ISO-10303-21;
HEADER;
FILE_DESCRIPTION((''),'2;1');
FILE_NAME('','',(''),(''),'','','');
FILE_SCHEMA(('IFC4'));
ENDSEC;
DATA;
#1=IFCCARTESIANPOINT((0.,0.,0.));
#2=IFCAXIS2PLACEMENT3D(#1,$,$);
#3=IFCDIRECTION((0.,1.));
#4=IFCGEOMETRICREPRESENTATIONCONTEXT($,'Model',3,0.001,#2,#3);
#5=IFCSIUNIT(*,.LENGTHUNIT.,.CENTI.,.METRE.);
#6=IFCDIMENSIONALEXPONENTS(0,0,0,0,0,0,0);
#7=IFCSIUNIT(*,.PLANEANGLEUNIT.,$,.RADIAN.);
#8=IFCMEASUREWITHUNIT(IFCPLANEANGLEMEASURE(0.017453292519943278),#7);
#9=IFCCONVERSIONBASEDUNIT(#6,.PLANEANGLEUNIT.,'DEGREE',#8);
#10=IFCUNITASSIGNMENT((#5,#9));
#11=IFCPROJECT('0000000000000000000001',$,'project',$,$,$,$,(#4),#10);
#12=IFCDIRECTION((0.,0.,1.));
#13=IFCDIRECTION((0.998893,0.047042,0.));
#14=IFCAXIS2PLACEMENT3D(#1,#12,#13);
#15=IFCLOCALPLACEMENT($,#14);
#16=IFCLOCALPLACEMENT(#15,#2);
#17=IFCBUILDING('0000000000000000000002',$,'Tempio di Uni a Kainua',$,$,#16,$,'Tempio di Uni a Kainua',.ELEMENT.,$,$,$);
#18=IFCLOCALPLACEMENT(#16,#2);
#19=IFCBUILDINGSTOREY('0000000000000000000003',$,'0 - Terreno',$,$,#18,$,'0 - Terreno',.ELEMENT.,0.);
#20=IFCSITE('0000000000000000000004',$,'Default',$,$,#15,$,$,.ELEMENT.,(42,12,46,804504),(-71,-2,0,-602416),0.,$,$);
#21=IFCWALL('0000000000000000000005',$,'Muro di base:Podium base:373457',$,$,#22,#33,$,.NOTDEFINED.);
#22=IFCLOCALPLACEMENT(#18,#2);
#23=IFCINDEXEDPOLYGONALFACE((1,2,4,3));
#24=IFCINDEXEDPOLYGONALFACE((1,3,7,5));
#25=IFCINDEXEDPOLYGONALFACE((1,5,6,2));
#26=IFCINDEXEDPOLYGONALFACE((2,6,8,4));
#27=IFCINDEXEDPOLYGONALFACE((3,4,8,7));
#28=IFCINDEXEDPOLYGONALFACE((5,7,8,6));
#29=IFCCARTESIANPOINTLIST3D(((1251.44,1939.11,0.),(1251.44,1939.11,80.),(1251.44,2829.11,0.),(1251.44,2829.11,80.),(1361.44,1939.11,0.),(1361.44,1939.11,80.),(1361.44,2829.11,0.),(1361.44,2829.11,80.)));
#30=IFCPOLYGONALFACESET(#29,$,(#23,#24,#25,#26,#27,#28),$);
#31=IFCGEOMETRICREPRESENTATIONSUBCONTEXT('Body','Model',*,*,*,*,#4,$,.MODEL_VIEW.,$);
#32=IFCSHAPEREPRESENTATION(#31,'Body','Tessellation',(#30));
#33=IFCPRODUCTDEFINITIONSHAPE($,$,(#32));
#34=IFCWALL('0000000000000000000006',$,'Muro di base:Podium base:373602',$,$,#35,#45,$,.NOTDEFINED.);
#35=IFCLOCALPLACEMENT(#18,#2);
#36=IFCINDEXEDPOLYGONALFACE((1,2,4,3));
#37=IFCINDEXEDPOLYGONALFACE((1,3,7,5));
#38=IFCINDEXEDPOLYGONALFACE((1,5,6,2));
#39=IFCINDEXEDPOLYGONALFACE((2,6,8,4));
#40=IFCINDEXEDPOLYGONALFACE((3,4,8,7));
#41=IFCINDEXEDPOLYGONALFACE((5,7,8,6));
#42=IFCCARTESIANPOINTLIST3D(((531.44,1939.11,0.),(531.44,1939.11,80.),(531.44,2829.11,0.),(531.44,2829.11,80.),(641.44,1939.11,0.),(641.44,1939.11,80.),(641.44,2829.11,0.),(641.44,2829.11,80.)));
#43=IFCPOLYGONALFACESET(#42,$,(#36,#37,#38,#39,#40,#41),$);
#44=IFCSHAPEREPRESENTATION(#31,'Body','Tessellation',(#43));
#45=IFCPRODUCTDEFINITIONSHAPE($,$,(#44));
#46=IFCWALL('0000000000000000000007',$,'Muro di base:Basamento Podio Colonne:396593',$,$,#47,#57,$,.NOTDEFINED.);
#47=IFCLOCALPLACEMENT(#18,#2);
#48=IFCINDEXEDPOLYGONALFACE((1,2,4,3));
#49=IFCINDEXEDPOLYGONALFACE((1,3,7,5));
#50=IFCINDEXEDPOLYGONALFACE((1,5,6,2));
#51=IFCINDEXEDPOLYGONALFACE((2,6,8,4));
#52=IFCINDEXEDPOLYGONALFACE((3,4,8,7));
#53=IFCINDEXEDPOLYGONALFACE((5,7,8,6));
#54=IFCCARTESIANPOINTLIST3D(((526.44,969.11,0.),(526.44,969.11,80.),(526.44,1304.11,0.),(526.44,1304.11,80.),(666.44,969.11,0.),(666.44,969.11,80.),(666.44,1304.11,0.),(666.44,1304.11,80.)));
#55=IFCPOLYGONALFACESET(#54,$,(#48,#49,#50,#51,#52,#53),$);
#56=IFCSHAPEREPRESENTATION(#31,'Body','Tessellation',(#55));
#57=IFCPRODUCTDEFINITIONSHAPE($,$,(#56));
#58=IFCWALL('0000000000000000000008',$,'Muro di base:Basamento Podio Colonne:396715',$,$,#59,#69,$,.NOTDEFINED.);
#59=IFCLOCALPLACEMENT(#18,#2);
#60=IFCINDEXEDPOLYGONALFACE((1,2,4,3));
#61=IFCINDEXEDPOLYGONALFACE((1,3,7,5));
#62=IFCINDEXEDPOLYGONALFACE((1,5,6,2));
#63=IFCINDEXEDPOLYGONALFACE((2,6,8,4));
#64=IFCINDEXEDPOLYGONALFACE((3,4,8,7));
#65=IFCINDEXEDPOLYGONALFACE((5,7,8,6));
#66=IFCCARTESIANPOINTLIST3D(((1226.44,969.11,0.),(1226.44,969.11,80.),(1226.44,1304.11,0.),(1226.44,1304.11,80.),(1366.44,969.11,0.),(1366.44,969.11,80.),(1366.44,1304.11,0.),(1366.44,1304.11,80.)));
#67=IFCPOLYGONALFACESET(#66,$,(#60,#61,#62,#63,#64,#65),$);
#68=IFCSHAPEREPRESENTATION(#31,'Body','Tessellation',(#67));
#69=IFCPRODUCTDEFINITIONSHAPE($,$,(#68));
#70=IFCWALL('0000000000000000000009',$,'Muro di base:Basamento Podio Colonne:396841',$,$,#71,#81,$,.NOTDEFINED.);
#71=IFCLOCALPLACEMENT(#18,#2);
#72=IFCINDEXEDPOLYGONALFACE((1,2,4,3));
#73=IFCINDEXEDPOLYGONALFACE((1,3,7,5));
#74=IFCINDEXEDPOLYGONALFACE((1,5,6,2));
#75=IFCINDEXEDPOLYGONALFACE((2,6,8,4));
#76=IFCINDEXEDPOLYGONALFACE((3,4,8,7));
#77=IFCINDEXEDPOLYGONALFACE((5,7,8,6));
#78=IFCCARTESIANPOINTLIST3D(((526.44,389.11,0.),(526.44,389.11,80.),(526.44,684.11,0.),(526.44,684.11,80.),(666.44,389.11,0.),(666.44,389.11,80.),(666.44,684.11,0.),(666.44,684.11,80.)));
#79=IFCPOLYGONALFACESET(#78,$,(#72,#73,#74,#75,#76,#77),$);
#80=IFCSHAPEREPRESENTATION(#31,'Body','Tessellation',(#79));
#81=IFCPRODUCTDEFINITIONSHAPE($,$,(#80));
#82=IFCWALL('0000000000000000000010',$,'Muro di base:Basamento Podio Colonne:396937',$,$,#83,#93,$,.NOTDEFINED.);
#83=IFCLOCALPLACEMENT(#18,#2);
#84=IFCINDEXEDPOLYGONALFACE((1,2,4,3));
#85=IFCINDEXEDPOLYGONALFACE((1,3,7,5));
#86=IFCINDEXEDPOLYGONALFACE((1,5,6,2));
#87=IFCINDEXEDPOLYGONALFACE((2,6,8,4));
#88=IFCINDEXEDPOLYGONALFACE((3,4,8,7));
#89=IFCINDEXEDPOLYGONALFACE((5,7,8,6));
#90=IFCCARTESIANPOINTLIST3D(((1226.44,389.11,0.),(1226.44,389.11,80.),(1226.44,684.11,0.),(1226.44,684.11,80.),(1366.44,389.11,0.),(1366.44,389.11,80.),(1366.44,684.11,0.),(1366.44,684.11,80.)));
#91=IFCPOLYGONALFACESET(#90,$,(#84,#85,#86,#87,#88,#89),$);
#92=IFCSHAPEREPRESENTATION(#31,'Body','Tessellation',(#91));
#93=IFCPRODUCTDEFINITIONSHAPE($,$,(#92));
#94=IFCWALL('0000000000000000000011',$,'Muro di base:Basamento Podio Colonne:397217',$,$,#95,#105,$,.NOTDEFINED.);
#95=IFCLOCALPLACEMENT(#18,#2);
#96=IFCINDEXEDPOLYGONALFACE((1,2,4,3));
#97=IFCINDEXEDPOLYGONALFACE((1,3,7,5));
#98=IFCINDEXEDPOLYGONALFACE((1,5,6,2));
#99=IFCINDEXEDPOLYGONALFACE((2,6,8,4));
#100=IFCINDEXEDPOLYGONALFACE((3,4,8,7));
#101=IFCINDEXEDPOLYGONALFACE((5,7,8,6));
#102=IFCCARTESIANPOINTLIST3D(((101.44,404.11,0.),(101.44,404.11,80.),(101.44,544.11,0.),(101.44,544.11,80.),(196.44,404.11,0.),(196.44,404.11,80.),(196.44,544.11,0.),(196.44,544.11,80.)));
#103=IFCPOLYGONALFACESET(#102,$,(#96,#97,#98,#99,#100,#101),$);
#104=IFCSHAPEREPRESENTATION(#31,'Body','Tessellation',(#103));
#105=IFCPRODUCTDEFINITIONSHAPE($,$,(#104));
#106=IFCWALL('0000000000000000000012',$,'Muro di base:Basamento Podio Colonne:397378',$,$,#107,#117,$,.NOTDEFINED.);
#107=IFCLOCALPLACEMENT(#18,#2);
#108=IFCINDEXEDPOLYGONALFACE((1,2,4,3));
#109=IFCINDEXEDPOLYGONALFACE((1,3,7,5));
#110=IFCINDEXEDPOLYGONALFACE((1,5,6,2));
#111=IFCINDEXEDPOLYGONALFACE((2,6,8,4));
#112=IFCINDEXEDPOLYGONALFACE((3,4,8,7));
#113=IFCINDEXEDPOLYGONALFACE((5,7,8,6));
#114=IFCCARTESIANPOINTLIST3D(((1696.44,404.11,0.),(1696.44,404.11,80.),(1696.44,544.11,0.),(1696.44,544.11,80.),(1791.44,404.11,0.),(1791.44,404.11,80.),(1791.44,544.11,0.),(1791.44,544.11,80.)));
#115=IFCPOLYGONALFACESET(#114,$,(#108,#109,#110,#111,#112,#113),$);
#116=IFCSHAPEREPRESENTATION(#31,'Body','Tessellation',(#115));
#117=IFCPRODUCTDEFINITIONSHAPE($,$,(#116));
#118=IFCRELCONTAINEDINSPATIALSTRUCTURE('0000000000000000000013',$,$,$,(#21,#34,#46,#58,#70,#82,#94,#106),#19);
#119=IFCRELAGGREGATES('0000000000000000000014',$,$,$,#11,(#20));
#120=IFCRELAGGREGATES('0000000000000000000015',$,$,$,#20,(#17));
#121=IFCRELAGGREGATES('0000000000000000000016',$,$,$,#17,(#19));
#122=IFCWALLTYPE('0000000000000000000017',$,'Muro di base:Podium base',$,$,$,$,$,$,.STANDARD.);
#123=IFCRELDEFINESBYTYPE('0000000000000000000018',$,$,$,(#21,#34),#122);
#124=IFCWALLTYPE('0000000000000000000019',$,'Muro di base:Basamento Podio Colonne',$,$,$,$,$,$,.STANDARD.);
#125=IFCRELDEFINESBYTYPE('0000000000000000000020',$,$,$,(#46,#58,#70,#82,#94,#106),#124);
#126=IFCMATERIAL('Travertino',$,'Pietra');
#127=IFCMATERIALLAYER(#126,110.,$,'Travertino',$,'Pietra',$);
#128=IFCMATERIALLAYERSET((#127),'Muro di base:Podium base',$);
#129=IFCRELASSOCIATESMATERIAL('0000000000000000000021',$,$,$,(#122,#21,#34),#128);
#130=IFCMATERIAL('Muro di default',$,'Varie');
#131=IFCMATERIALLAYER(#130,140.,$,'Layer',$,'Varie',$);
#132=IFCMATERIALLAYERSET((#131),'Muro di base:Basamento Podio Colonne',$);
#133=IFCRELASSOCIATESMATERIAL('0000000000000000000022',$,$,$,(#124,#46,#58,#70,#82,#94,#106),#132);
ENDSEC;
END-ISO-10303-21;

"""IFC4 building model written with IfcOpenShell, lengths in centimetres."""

from ifc_helpers import new_model, entity, si_unit, converted_unit, direction, frame, frame_2d, origin, place, context, subcontext, project, spatial, polyline, rectangle, extrude, clip, bounded_halfspace, material, layer, layer_set, layer_usage, type_object, element, save


model = new_model("IFC4")

# Units and contexts
model_context = context("Model", 3, precision=0.001, world=origin(), true_north=direction((0.0, 1.0)))
body_context = subcontext(model_context, "Body", "Model", "MODEL_VIEW")
ifc_project = project(units=[si_unit("LENGTHUNIT", "METRE", prefix="CENTI"), converted_unit("PLANEANGLEUNIT", "DEGREE", entity("IfcPlaneAngleMeasure", 0.017453292519943278), si_unit("PLANEANGLEUNIT", "RADIAN"), dimensions=[0, 0, 0, 0, 0, 0, 0])], contexts=[model_context])

# Site, building, storey
site_placement = place(None, frame((0.0, 0.0, 0.0), z_axis=(0.0, 0.0, 1.0), x_axis=(0.998893, 0.047042, 0.0)))
site = spatial("IfcSite", under=ifc_project, at=site_placement, Name="Default", CompositionType="ELEMENT", RefLatitude=(42, 12, 46, 804504), RefLongitude=(-71, -2, 0, -602416), RefElevation=0.0)
building_placement = place(site_placement, origin())
building = spatial("IfcBuilding", under=site, at=building_placement, Name="Tempio di Uni a Kainua", LongName="Tempio di Uni a Kainua", CompositionType="ELEMENT")
storey_placement = place(building_placement, origin())
storey = spatial("IfcBuildingStorey", under=building, at=storey_placement, Name="0 - Terreno", LongName="0 - Terreno", CompositionType="ELEMENT", Elevation=0.0)

# Walls
ifc_material_1 = material(Name="Travertino", Category="Pietra")
ifc_layer_1 = layer(ifc_material_1, 110.0, Name="Travertino", Category="Pietra")
ifc_layer_set_1 = layer_set([ifc_layer_1], Name="Muro di base:Podium base")
wall_type_1 = type_object("IfcWallType", Name="Muro di base:Podium base", PredefinedType="STANDARD", material=ifc_layer_set_1)
ifc_layer_usage_1 = layer_usage(ifc_layer_set_1, "AXIS2", "NEGATIVE", 55.0)
wall_1_placement = place(storey_placement, frame((1306.44, 1939.11, 0.0), z_axis=(0.0, 0.0, 1.0), x_axis=(0.0, 1.0, 0.0)))
element("IfcWall", 1, at=wall_1_placement, inside=storey, type_object=wall_type_1, material=ifc_layer_usage_1, Name="Muro di base:Podium base:373457", PredefinedType="NOTDEFINED", context=body_context, shape_type="Clipping", body=[
    clip(extrude(rectangle(XDim=890.0, YDim=110.0, at=frame_2d((445.0, 0.0), x_axis=(-1.0, 0.0))), origin(), (0.0, 0.0, 1.0), 80.0), bounded_halfspace(frame((0.0, -55.0, 80.0), z_axis=(0.0, 0.0, -1.0), x_axis=(-1.0, 0.0, 0.0)), True, frame((0.0, -55.0, 80.0)), polyline([(0.0, 0.0), (340.0, 0.0), (450.0, 0.0), (890.0, 0.0), (890.0, 110.0), (750.0, 110.0), (640.0, 110.0), (0.0, 110.0), (0.0, 0.0)]))),
])
ifc_layer_usage_2 = layer_usage(ifc_layer_set_1, "AXIS2", "NEGATIVE", 55.0)
wall_2_placement = place(storey_placement, frame((586.44, 1939.11, 0.0), z_axis=(0.0, 0.0, 1.0), x_axis=(0.0, 1.0, 0.0)))
element("IfcWall", 2, at=wall_2_placement, inside=storey, type_object=wall_type_1, material=ifc_layer_usage_2, Name="Muro di base:Podium base:373602", PredefinedType="NOTDEFINED", context=body_context, shape_type="Clipping", body=[
    clip(extrude(rectangle(XDim=890.0, YDim=110.0, at=frame_2d((445.0, 0.0), x_axis=(-1.0, 0.0))), origin(), (0.0, 0.0, 1.0), 80.0), bounded_halfspace(frame((0.0, -55.0, 80.0), z_axis=(0.0, 0.0, -1.0), x_axis=(-1.0, 0.0, 0.0)), True, frame((0.0, -55.0, 80.0)), polyline([(0.0, 0.0), (640.0, 0.0), (750.0, 0.0), (890.0, 0.0), (890.0, 110.0), (450.0, 110.0), (340.0, 110.0), (0.0, 110.0), (0.0, 0.0)]))),
])
ifc_material_2 = material(Name="Muro di default", Category="Varie")
ifc_layer_2 = layer(ifc_material_2, 140.0, Name="Layer", Category="Varie")
ifc_layer_set_2 = layer_set([ifc_layer_2], Name="Muro di base:Basamento Podio Colonne")
ifc_layer_usage_3 = layer_usage(ifc_layer_set_2, "AXIS2", "NEGATIVE", 70.0)
wall_type_2 = type_object("IfcWallType", Name="Muro di base:Basamento Podio Colonne", PredefinedType="STANDARD", material=ifc_layer_set_2)
wall_3_placement = place(storey_placement, frame((596.44, 969.11, 0.0), z_axis=(0.0, 0.0, 1.0), x_axis=(0.0, 1.0, 0.0)))
element("IfcWall", 3, at=wall_3_placement, inside=storey, type_object=wall_type_2, material=ifc_layer_usage_3, Name="Muro di base:Basamento Podio Colonne:396593", PredefinedType="NOTDEFINED", context=body_context, shape_type="Clipping", body=[
    clip(extrude(rectangle(XDim=335.0, YDim=140.0, at=frame_2d((167.5, 0.0), x_axis=(-1.0, 0.0))), origin(), (0.0, 0.0, 1.0), 80.0), bounded_halfspace(frame((0.0, -70.0, 80.0), z_axis=(0.0, 0.0, -1.0), x_axis=(-1.0, 0.0, 0.0)), True, frame((0.0, -70.0, 80.0)), polyline([(0.0, 0.0), (335.0, 0.0), (335.0, 140.0), (0.0, 140.0), (0.0, 0.0)]))),
])
ifc_layer_usage_4 = layer_usage(ifc_layer_set_2, "AXIS2", "NEGATIVE", 70.0)
wall_4_placement = place(storey_placement, frame((1296.44, 969.11, 0.0), z_axis=(0.0, 0.0, 1.0), x_axis=(0.0, 1.0, 0.0)))
element("IfcWall", 4, at=wall_4_placement, inside=storey, type_object=wall_type_2, material=ifc_layer_usage_4, Name="Muro di base:Basamento Podio Colonne:396715", PredefinedType="NOTDEFINED", context=body_context, shape_type="Clipping", body=[
    clip(extrude(rectangle(XDim=335.0, YDim=140.0, at=frame_2d((167.5, 0.0), x_axis=(-1.0, 0.0))), origin(), (0.0, 0.0, 1.0), 80.0), bounded_halfspace(frame((0.0, -70.0, 80.0), z_axis=(0.0, 0.0, -1.0), x_axis=(-1.0, 0.0, 0.0)), True, frame((0.0, -70.0, 80.0)), polyline([(0.0, 0.0), (335.0, 0.0), (335.0, 140.0), (0.0, 140.0), (0.0, 0.0)]))),
])
ifc_layer_usage_5 = layer_usage(ifc_layer_set_2, "AXIS2", "NEGATIVE", 70.0)
wall_5_placement = place(storey_placement, frame((596.44, 389.11, 0.0), z_axis=(0.0, 0.0, 1.0), x_axis=(0.0, 1.0, 0.0)))
element("IfcWall", 5, at=wall_5_placement, inside=storey, type_object=wall_type_2, material=ifc_layer_usage_5, Name="Muro di base:Basamento Podio Colonne:396841", PredefinedType="NOTDEFINED", context=body_context, shape_type="Clipping", body=[
    clip(extrude(rectangle(XDim=295.0, YDim=140.0, at=frame_2d((147.5, 0.0), x_axis=(-1.0, 0.0))), origin(), (0.0, 0.0, 1.0), 80.0), bounded_halfspace(frame((0.0, -70.0, 80.0), z_axis=(0.0, 0.0, -1.0), x_axis=(-1.0, 0.0, 0.0)), True, frame((0.0, -70.0, 80.0)), polyline([(0.0, 0.0), (295.0, 0.0), (295.0, 140.0), (0.0, 140.0), (0.0, 0.0)]))),
])
ifc_layer_usage_6 = layer_usage(ifc_layer_set_2, "AXIS2", "NEGATIVE", 70.0)
wall_6_placement = place(storey_placement, frame((1296.44, 389.11, 0.0), z_axis=(0.0, 0.0, 1.0), x_axis=(0.0, 1.0, 0.0)))
element("IfcWall", 6, at=wall_6_placement, inside=storey, type_object=wall_type_2, material=ifc_layer_usage_6, Name="Muro di base:Basamento Podio Colonne:396937", PredefinedType="NOTDEFINED", context=body_context, shape_type="Clipping", body=[
    clip(extrude(rectangle(XDim=295.0, YDim=140.0, at=frame_2d((147.5, 0.0), x_axis=(-1.0, 0.0))), origin(), (0.0, 0.0, 1.0), 80.0), bounded_halfspace(frame((0.0, -70.0, 80.0), z_axis=(0.0, 0.0, -1.0), x_axis=(-1.0, 0.0, 0.0)), True, frame((0.0, -70.0, 80.0)), polyline([(0.0, 0.0), (295.0, 0.0), (295.0, 140.0), (0.0, 140.0), (0.0, 0.0)]))),
])
ifc_layer_usage_7 = layer_usage(ifc_layer_set_2, "AXIS2", "NEGATIVE", 70.0)
wall_7_placement = place(storey_placement, frame((101.44, 474.11, 0.0)))
element("IfcWall", 7, at=wall_7_placement, inside=storey, type_object=wall_type_2, material=ifc_layer_usage_7, Name="Muro di base:Basamento Podio Colonne:397217", PredefinedType="NOTDEFINED", context=body_context, shape_type="Clipping", body=[
    clip(extrude(rectangle(XDim=95.0, YDim=140.0, at=frame_2d((47.5, 0.0), x_axis=(-1.0, 0.0))), origin(), (0.0, 0.0, 1.0), 80.0), bounded_halfspace(frame((0.0, -70.0, 80.0), z_axis=(0.0, 0.0, -1.0), x_axis=(0.0, -1.0, 0.0)), True, frame((0.0, -70.0, 80.0)), polyline([(0.0, 0.0), (95.0, 0.0), (95.0, 140.0), (0.0, 140.0), (0.0, 0.0)]))),
])
ifc_layer_usage_8 = layer_usage(ifc_layer_set_2, "AXIS2", "NEGATIVE", 70.0)
wall_8_placement = place(storey_placement, frame((1791.44, 474.11, 0.0), z_axis=(0.0, 0.0, 1.0), x_axis=(-1.0, 0.0, 0.0)))
element("IfcWall", 8, at=wall_8_placement, inside=storey, type_object=wall_type_2, material=ifc_layer_usage_8, Name="Muro di base:Basamento Podio Colonne:397378", PredefinedType="NOTDEFINED", context=body_context, shape_type="Clipping", body=[
    clip(extrude(rectangle(XDim=95.0, YDim=140.0, at=frame_2d((47.5, 0.0), x_axis=(-1.0, 0.0))), origin(), (0.0, 0.0, 1.0), 80.0), bounded_halfspace(frame((0.0, -70.0, 80.0), z_axis=(0.0, 0.0, -1.0), x_axis=(0.0, 1.0, 0.0)), True, frame((0.0, -70.0, 80.0)), polyline([(0.0, 0.0), (95.0, 0.0), (95.0, 140.0), (0.0, 140.0), (0.0, 0.0)]))),
])

save(model, "model.ifc")
